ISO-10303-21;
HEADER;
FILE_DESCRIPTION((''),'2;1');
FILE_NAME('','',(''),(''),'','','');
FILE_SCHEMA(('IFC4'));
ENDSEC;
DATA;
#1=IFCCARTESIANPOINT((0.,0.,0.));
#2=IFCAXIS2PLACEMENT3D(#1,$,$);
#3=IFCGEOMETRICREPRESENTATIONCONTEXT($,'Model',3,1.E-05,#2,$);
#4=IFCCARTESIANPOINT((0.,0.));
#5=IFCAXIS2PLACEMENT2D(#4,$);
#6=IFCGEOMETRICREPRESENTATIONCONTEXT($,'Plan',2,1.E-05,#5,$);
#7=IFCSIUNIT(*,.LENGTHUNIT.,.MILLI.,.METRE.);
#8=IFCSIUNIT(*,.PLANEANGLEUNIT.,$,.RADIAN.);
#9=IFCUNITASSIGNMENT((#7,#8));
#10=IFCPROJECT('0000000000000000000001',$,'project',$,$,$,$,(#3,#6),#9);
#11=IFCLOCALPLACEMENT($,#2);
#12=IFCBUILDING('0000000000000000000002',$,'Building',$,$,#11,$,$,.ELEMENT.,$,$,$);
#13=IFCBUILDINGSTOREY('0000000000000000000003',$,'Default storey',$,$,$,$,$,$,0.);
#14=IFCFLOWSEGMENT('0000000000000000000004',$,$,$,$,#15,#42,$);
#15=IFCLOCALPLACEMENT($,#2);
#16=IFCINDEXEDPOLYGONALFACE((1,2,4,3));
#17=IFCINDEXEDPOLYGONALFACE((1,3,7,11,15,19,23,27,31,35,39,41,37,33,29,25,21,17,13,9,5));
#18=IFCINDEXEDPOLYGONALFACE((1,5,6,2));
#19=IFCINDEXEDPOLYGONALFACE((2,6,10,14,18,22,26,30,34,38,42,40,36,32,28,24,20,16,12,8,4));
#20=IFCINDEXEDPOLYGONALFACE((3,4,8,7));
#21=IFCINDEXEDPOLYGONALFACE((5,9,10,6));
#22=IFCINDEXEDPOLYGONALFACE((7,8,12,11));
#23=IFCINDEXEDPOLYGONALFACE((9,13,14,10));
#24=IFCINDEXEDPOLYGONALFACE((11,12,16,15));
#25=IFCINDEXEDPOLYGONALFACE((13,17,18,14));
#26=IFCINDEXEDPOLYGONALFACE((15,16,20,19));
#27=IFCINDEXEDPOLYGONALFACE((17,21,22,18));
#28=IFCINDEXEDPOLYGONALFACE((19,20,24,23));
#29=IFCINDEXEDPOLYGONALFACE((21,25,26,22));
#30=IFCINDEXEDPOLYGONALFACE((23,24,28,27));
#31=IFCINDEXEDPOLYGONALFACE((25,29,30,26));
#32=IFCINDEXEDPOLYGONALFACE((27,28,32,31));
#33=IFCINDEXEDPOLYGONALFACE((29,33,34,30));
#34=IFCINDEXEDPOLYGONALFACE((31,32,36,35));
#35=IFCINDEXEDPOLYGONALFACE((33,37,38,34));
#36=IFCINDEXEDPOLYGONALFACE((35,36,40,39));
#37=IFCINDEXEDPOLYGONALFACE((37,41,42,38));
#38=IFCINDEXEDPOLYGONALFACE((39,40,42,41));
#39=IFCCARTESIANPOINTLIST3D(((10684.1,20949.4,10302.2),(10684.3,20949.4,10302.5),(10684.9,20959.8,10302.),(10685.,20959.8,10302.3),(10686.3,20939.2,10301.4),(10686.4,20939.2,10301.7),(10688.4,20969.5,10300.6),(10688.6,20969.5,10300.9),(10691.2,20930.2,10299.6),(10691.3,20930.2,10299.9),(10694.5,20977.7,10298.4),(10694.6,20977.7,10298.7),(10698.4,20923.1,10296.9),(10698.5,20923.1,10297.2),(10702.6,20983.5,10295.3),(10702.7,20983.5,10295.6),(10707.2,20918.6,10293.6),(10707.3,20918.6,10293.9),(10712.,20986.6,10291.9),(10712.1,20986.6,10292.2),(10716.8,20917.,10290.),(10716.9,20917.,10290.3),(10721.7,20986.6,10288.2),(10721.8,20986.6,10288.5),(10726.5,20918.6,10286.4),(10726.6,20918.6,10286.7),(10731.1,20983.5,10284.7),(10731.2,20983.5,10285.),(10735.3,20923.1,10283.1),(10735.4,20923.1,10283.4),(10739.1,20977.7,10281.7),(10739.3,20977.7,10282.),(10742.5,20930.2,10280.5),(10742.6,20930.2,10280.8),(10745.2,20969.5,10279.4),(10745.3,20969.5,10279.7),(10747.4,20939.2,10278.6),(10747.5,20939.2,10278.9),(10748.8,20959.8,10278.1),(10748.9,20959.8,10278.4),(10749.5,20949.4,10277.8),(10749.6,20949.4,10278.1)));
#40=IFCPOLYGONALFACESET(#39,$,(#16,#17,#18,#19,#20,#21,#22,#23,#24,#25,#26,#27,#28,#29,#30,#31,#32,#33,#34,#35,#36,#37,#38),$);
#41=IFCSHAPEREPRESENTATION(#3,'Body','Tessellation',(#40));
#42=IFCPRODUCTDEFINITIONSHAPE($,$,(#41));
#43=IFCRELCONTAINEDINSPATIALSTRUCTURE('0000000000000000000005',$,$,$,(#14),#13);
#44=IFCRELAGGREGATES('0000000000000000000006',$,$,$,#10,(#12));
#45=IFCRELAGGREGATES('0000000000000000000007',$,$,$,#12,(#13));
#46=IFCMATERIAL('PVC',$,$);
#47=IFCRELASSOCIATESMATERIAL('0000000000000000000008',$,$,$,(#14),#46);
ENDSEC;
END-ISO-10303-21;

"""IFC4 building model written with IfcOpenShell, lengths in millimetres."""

from ifc_helpers import new_model, si_unit, frame, origin, origin_2d, place, context, project, spatial, circle, extrude, material, element, save


model = new_model("IFC4")

# Units and contexts
model_context = context("Model", 3, precision=1e-05, world=origin())
plan_context = context("Plan", 2, precision=1e-05, world=origin_2d())
ifc_project = project(units=[si_unit("LENGTHUNIT", "METRE", prefix="MILLI"), si_unit("PLANEANGLEUNIT", "RADIAN")], contexts=[model_context, plan_context])

# Building, storey
placement = place(None, origin())
building = spatial("IfcBuilding", under=ifc_project, at=placement, Name="Building", CompositionType="ELEMENT")
storey = spatial("IfcBuildingStorey", under=building, Name="Default storey", Elevation=0.0)

# Flow segment
ifc_material_1 = material(Name="PVC")
element("IfcFlowSegment", 1, at=placement, inside=storey, material=ifc_material_1, context=model_context, shape_type="SweptSolid", body=[
    extrude(circle(Radius=35.0, at=origin_2d()), frame((10716.8, 20952.0, 10290.0), z_axis=(0.109495, 0.0, 0.29329), x_axis=(0.0, -109.494844, 0.0)), (0.0, 0.0, 1.0), 0.3),
])

save(model, "model.ifc")
